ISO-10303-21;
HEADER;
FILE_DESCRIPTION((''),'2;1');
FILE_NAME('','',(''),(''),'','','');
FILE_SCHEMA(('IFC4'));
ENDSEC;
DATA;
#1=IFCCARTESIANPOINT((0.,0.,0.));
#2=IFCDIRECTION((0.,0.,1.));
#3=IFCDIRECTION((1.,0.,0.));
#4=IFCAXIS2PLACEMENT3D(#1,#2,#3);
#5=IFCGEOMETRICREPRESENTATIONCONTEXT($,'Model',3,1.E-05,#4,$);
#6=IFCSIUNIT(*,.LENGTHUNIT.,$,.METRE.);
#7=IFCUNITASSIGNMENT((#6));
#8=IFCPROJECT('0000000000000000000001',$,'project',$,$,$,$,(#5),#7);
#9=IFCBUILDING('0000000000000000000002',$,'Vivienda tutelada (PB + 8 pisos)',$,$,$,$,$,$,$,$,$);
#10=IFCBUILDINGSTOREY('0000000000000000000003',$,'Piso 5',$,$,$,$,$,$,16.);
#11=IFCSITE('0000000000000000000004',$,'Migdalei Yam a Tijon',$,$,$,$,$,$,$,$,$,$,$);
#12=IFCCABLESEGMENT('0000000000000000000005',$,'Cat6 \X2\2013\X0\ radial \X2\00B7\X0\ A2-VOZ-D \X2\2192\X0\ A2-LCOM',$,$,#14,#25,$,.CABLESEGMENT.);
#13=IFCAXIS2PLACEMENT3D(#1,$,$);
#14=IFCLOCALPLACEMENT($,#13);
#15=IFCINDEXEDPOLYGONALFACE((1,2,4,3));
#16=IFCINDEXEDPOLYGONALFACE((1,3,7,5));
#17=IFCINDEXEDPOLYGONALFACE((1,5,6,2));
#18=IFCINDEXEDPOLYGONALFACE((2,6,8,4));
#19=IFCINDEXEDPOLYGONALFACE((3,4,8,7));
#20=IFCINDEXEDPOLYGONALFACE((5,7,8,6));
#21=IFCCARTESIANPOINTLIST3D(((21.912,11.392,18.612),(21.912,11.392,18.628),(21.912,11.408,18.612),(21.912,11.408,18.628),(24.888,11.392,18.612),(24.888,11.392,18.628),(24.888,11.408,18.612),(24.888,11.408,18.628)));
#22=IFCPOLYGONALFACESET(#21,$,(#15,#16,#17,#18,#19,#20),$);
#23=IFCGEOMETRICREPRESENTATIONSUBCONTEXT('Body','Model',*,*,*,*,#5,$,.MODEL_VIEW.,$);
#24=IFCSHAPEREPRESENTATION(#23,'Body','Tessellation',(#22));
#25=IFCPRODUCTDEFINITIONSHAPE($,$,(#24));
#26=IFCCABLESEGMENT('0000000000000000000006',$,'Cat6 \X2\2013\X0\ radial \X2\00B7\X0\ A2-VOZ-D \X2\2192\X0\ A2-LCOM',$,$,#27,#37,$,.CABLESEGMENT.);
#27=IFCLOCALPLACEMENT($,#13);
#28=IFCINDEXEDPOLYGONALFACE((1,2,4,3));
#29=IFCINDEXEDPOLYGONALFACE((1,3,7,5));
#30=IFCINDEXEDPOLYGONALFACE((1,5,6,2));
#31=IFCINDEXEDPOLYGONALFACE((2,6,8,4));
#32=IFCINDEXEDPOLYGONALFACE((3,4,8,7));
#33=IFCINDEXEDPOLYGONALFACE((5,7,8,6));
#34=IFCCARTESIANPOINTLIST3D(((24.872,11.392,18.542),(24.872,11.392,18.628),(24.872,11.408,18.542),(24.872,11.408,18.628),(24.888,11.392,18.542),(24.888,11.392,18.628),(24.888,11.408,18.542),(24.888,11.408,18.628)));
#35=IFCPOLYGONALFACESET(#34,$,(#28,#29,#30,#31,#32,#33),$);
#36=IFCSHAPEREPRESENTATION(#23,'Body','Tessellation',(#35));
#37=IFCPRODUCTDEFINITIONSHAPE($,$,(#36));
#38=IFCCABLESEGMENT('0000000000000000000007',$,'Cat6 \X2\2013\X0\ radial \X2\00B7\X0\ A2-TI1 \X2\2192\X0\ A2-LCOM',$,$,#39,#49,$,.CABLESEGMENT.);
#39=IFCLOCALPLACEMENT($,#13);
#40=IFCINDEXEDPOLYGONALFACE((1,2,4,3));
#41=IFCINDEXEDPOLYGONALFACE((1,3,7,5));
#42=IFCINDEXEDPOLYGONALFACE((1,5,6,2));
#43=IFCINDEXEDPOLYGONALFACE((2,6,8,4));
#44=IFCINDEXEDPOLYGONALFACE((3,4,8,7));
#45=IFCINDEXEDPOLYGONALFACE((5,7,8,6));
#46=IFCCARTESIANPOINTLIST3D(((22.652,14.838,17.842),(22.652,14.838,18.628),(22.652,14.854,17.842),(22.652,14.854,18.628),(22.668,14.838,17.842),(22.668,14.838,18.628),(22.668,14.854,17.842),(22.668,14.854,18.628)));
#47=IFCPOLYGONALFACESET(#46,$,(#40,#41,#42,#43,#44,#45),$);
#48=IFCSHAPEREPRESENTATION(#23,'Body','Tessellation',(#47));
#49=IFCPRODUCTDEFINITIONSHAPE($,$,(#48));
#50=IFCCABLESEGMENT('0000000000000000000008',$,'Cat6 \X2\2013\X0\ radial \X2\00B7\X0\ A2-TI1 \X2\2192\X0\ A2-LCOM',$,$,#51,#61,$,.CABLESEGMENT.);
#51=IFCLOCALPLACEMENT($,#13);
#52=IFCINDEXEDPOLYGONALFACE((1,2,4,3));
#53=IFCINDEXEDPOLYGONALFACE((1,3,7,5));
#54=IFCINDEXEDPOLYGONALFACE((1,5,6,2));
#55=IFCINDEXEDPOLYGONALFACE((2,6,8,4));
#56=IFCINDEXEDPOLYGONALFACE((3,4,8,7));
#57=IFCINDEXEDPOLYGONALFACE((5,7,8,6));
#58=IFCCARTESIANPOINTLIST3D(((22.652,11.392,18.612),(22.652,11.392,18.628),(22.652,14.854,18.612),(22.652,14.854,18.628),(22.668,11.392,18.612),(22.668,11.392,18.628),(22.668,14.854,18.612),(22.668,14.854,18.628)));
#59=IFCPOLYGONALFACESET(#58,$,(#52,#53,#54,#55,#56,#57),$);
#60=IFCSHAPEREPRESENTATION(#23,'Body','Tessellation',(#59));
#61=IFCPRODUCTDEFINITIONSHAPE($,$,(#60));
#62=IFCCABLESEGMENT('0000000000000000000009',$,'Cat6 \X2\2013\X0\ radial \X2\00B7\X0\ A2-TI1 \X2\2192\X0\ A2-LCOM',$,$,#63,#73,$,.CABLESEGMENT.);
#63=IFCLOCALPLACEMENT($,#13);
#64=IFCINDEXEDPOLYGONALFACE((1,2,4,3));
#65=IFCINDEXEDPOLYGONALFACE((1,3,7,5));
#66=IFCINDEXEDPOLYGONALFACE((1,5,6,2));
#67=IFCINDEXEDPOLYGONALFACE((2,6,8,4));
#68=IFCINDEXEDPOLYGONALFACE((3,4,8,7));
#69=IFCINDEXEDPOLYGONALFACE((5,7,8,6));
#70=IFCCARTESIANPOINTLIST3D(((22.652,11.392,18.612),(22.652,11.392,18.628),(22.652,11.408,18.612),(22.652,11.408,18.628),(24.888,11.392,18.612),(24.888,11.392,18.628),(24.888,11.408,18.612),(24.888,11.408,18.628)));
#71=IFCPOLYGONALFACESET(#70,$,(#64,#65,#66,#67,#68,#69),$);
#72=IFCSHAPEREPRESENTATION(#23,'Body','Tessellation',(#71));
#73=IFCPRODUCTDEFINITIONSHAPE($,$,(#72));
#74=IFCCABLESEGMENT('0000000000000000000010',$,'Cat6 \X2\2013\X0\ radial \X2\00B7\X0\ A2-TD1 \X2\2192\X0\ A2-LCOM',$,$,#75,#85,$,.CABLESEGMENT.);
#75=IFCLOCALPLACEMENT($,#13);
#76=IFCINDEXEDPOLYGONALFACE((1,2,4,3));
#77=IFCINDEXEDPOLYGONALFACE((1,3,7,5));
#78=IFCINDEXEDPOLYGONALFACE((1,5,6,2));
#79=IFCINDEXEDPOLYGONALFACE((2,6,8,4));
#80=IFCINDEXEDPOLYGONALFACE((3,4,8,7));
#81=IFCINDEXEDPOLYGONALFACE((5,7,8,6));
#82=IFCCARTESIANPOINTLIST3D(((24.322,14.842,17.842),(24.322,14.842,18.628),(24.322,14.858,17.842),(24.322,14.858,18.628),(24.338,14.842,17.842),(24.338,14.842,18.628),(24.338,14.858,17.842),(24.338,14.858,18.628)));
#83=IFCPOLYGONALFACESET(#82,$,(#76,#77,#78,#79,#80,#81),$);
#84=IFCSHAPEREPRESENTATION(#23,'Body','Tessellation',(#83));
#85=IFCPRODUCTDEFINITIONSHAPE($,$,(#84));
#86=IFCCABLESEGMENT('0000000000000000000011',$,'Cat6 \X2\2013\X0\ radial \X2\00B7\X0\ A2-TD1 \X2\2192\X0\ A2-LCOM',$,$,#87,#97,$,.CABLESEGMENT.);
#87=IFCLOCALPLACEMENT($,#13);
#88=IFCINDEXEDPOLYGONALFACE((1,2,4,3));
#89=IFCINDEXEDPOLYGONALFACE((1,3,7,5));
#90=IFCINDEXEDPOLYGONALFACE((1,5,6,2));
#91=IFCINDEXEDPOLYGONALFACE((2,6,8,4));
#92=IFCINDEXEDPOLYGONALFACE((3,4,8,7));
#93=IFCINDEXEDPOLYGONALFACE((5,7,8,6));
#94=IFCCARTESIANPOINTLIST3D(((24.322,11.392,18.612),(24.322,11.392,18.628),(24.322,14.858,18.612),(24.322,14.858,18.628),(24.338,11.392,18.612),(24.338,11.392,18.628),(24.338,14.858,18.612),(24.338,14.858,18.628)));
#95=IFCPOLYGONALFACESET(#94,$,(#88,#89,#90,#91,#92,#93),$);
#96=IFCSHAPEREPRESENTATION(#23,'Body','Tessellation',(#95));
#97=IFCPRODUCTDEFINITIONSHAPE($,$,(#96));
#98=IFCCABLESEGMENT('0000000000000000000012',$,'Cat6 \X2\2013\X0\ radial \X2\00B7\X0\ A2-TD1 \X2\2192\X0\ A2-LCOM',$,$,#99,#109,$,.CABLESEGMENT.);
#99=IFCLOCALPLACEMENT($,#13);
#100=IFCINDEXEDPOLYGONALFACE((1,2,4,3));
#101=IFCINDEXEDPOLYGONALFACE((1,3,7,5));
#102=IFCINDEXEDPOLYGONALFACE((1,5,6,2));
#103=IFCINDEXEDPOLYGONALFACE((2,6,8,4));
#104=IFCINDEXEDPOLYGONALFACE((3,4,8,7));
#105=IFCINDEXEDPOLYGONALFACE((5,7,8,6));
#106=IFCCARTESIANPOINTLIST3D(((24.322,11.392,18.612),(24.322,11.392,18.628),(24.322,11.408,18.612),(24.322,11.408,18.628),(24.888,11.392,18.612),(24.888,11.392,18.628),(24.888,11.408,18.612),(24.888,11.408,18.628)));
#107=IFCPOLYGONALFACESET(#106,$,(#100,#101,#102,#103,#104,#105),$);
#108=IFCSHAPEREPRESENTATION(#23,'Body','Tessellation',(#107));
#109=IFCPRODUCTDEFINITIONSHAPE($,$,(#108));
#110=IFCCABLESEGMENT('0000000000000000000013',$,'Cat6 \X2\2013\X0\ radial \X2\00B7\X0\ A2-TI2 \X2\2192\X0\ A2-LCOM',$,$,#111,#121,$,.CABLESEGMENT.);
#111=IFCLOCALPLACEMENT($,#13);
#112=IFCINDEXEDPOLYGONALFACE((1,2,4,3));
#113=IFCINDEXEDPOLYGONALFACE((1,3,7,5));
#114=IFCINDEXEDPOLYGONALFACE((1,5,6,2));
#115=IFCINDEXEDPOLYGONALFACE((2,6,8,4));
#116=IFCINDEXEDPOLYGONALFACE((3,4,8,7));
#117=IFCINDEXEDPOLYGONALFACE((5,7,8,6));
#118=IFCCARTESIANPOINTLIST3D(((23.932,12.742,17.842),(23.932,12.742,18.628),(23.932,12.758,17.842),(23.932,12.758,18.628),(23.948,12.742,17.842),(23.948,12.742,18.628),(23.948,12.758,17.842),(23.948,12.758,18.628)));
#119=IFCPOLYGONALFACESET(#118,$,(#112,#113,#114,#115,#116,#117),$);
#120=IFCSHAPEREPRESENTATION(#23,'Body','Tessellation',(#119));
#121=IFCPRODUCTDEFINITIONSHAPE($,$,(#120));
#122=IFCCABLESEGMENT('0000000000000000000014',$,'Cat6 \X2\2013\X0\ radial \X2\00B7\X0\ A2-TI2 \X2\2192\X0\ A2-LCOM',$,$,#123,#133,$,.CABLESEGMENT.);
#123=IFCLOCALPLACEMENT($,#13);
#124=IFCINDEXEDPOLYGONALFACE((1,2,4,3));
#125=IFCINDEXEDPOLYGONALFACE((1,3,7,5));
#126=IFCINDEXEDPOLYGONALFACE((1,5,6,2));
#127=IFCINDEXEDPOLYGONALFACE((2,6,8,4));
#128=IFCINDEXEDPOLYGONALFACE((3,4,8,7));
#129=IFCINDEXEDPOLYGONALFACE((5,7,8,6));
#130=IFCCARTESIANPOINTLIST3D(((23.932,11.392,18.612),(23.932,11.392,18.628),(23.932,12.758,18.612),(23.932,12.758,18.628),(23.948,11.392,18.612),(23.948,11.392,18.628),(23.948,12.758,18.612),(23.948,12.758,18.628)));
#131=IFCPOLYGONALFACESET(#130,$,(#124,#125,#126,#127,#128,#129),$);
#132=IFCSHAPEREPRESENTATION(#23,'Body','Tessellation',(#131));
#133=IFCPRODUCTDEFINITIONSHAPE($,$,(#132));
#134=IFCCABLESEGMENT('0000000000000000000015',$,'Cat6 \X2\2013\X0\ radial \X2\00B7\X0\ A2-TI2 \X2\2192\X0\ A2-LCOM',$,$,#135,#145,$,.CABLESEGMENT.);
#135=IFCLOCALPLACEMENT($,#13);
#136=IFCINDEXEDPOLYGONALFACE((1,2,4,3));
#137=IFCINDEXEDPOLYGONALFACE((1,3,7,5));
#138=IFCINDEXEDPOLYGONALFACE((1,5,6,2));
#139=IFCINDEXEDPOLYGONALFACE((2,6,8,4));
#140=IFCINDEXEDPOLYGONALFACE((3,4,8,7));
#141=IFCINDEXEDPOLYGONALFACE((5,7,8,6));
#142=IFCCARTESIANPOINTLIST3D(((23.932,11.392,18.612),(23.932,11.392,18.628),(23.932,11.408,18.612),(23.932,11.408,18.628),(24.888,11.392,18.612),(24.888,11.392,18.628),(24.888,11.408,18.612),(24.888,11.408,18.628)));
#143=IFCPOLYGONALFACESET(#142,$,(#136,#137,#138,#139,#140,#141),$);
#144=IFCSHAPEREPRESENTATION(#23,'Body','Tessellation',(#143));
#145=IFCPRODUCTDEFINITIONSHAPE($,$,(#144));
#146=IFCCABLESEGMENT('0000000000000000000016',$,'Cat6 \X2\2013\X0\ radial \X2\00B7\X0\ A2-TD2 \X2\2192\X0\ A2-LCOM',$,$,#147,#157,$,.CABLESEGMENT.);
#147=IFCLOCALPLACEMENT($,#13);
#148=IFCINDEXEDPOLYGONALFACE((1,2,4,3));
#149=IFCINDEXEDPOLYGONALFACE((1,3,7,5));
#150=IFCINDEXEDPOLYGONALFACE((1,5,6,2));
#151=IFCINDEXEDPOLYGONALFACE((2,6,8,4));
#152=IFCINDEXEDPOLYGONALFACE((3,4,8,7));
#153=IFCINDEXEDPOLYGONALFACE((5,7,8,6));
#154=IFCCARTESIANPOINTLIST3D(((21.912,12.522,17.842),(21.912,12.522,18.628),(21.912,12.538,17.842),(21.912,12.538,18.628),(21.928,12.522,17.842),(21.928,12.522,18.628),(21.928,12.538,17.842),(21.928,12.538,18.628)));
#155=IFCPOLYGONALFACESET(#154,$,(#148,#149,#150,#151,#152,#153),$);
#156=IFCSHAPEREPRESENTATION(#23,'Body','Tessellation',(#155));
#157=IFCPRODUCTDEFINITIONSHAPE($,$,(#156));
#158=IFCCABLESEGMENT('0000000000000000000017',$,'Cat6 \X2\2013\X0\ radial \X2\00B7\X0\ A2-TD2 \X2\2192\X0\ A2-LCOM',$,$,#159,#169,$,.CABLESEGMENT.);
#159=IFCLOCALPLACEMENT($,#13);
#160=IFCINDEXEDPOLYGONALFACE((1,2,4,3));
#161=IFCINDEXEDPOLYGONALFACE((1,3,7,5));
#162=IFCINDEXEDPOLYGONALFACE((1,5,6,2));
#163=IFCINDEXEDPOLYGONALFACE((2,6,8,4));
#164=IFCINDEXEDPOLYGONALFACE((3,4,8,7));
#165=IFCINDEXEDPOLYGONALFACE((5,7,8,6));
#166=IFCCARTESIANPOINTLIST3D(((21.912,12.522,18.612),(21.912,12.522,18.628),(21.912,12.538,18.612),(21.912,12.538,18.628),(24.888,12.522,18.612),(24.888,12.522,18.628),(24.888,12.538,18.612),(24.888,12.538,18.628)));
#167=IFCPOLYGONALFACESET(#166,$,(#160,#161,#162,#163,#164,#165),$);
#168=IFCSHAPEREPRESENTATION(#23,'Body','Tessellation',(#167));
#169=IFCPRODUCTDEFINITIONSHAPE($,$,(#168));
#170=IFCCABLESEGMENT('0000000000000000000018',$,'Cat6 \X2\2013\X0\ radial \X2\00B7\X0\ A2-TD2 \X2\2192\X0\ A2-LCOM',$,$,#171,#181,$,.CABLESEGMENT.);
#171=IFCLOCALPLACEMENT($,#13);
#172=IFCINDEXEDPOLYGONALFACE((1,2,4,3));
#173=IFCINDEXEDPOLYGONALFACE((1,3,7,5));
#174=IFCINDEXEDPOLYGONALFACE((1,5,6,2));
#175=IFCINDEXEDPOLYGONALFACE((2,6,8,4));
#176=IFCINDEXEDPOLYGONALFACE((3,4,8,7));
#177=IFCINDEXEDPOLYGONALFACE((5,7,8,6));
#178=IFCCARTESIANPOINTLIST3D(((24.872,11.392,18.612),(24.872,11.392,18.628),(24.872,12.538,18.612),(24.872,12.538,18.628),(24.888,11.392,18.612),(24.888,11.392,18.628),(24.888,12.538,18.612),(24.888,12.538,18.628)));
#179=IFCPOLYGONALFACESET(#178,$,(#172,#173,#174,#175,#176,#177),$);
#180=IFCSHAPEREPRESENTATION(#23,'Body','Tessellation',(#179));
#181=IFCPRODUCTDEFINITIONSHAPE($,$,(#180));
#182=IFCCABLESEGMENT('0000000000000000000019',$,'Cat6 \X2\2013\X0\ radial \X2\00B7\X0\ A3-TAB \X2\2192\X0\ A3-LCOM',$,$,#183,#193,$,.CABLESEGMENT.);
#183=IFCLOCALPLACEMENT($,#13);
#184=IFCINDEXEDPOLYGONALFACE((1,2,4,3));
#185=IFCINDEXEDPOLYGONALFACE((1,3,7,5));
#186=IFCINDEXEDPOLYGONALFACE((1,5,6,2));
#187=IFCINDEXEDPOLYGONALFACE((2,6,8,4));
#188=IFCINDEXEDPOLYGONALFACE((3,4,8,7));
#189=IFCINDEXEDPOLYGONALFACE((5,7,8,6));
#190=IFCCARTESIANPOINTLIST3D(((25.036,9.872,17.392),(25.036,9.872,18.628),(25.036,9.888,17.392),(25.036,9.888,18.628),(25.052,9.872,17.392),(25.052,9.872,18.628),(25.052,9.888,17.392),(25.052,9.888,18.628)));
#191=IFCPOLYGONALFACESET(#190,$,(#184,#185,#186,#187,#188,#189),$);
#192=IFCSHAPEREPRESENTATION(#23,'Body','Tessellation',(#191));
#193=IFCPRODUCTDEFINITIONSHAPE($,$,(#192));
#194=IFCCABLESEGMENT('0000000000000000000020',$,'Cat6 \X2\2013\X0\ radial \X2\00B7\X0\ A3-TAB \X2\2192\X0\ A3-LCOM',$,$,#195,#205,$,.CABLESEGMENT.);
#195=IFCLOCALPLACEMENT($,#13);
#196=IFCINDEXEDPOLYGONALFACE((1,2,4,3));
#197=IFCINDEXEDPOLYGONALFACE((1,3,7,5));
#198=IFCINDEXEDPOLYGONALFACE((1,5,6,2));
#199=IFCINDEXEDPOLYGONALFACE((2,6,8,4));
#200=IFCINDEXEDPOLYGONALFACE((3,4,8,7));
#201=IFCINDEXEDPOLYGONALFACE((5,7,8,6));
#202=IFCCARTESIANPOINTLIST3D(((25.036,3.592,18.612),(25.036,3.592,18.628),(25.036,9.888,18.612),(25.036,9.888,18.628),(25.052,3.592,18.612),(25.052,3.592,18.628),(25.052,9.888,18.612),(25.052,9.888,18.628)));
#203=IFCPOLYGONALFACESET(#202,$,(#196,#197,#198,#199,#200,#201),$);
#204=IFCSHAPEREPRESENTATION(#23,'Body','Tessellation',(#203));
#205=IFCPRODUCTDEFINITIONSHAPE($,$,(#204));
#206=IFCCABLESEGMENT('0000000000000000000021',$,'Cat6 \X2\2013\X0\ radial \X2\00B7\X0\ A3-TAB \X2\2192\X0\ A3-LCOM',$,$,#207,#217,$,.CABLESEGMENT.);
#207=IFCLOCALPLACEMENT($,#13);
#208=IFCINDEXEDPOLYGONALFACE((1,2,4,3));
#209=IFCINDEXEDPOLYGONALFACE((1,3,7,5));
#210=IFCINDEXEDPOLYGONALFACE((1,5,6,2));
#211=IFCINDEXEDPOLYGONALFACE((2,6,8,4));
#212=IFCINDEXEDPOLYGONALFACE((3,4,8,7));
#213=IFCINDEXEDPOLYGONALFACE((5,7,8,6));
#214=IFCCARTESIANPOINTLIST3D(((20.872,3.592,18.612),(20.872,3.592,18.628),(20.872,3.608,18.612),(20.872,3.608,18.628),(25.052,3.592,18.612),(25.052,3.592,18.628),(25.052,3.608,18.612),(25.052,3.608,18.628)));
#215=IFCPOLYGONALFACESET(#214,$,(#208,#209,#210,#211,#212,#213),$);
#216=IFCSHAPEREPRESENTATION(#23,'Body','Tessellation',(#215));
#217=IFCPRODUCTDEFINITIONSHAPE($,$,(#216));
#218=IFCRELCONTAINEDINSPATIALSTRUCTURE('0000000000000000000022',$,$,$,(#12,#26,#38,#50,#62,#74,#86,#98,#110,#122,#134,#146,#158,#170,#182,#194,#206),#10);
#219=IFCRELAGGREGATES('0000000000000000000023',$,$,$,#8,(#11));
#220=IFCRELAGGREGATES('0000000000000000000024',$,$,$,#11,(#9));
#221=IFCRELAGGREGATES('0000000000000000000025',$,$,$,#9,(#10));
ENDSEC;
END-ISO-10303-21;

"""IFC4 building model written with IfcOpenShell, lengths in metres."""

from ifc_helpers import new_model, si_unit, frame, origin_with_axes, context, subcontext, project, spatial, line, indexed_curve, outline, extrude, element, save


model = new_model("IFC4")

# Units and contexts
model_context = context("Model", 3, precision=1e-05, world=origin_with_axes())
body_context = subcontext(model_context, "Body", "Model", "MODEL_VIEW")
ifc_project = project(units=[si_unit("LENGTHUNIT", "METRE")], contexts=[model_context])

# Site, building, storey
site = spatial("IfcSite", under=ifc_project, Name="Migdalei Yam a Tijon")
building = spatial("IfcBuilding", under=site, Name="Vivienda tutelada (PB + 8 pisos)")
storey = spatial("IfcBuildingStorey", under=building, Name="Piso 5", Elevation=16.0)

# Cable segments
element("IfcCableSegment", 1, inside=storey, Name="Cat6 – radial · A2-VOZ-D → A2-LCOM", PredefinedType="CABLESEGMENT", context=body_context, shape_type="SweptSolid", body=[
    extrude(outline(indexed_curve([(0.0, 0.0), (2.976, 0.0), (2.976, 0.016), (0.0, 0.016)], segments=[line(1, 2, 3, 4, 1)])), frame((21.912, 11.392, 18.612), z_axis=(0.0, 0.0, 1.0), x_axis=(1.0, 0.0, 0.0)), (0.0, 0.0, 1.0), 0.016),
])
element("IfcCableSegment", 2, inside=storey, Name="Cat6 – radial · A2-VOZ-D → A2-LCOM", PredefinedType="CABLESEGMENT", context=body_context, shape_type="SweptSolid", body=[
    extrude(outline(indexed_curve([(0.0, 0.0), (0.016, 0.0), (0.016, 0.016), (0.0, 0.016)], segments=[line(1, 2, 3, 4, 1)])), frame((24.872, 11.392, 18.542), z_axis=(0.0, 0.0, 1.0), x_axis=(1.0, 0.0, 0.0)), (0.0, 0.0, 1.0), 0.086),
])
element("IfcCableSegment", 3, inside=storey, Name="Cat6 – radial · A2-TI1 → A2-LCOM", PredefinedType="CABLESEGMENT", context=body_context, shape_type="SweptSolid", body=[
    extrude(outline(indexed_curve([(0.0, 0.0), (0.016, 0.0), (0.016, 0.016), (0.0, 0.016)], segments=[line(1, 2, 3, 4, 1)])), frame((22.652, 14.838, 17.842), z_axis=(0.0, 0.0, 1.0), x_axis=(1.0, 0.0, 0.0)), (0.0, 0.0, 1.0), 0.786),
])
element("IfcCableSegment", 4, inside=storey, Name="Cat6 – radial · A2-TI1 → A2-LCOM", PredefinedType="CABLESEGMENT", context=body_context, shape_type="SweptSolid", body=[
    extrude(outline(indexed_curve([(0.0, 0.0), (0.016, 0.0), (0.016, 3.462), (0.0, 3.462)], segments=[line(1, 2, 3, 4, 1)])), frame((22.652, 11.392, 18.612), z_axis=(0.0, 0.0, 1.0), x_axis=(1.0, 0.0, 0.0)), (0.0, 0.0, 1.0), 0.016),
])
element("IfcCableSegment", 5, inside=storey, Name="Cat6 – radial · A2-TI1 → A2-LCOM", PredefinedType="CABLESEGMENT", context=body_context, shape_type="SweptSolid", body=[
    extrude(outline(indexed_curve([(0.0, 0.0), (2.236, 0.0), (2.236, 0.016), (0.0, 0.016)], segments=[line(1, 2, 3, 4, 1)])), frame((22.652, 11.392, 18.612), z_axis=(0.0, 0.0, 1.0), x_axis=(1.0, 0.0, 0.0)), (0.0, 0.0, 1.0), 0.016),
])
element("IfcCableSegment", 6, inside=storey, Name="Cat6 – radial · A2-TD1 → A2-LCOM", PredefinedType="CABLESEGMENT", context=body_context, shape_type="SweptSolid", body=[
    extrude(outline(indexed_curve([(0.0, 0.0), (0.016, 0.0), (0.016, 0.016), (0.0, 0.016)], segments=[line(1, 2, 3, 4, 1)])), frame((24.322, 14.842, 17.842), z_axis=(0.0, 0.0, 1.0), x_axis=(1.0, 0.0, 0.0)), (0.0, 0.0, 1.0), 0.786),
])
element("IfcCableSegment", 7, inside=storey, Name="Cat6 – radial · A2-TD1 → A2-LCOM", PredefinedType="CABLESEGMENT", context=body_context, shape_type="SweptSolid", body=[
    extrude(outline(indexed_curve([(0.0, 0.0), (0.016, 0.0), (0.016, 3.466), (0.0, 3.466)], segments=[line(1, 2, 3, 4, 1)])), frame((24.322, 11.392, 18.612), z_axis=(0.0, 0.0, 1.0), x_axis=(1.0, 0.0, 0.0)), (0.0, 0.0, 1.0), 0.016),
])
element("IfcCableSegment", 8, inside=storey, Name="Cat6 – radial · A2-TD1 → A2-LCOM", PredefinedType="CABLESEGMENT", context=body_context, shape_type="SweptSolid", body=[
    extrude(outline(indexed_curve([(0.0, 0.0), (0.566, 0.0), (0.566, 0.016), (0.0, 0.016)], segments=[line(1, 2, 3, 4, 1)])), frame((24.322, 11.392, 18.612), z_axis=(0.0, 0.0, 1.0), x_axis=(1.0, 0.0, 0.0)), (0.0, 0.0, 1.0), 0.016),
])
element("IfcCableSegment", 9, inside=storey, Name="Cat6 – radial · A2-TI2 → A2-LCOM", PredefinedType="CABLESEGMENT", context=body_context, shape_type="SweptSolid", body=[
    extrude(outline(indexed_curve([(0.0, 0.0), (0.016, 0.0), (0.016, 0.016), (0.0, 0.016)], segments=[line(1, 2, 3, 4, 1)])), frame((23.932, 12.742, 17.842), z_axis=(0.0, 0.0, 1.0), x_axis=(1.0, 0.0, 0.0)), (0.0, 0.0, 1.0), 0.786),
])
element("IfcCableSegment", 10, inside=storey, Name="Cat6 – radial · A2-TI2 → A2-LCOM", PredefinedType="CABLESEGMENT", context=body_context, shape_type="SweptSolid", body=[
    extrude(outline(indexed_curve([(0.0, 0.0), (0.016, 0.0), (0.016, 1.366), (0.0, 1.366)], segments=[line(1, 2, 3, 4, 1)])), frame((23.932, 11.392, 18.612), z_axis=(0.0, 0.0, 1.0), x_axis=(1.0, 0.0, 0.0)), (0.0, 0.0, 1.0), 0.016),
])
element("IfcCableSegment", 11, inside=storey, Name="Cat6 – radial · A2-TI2 → A2-LCOM", PredefinedType="CABLESEGMENT", context=body_context, shape_type="SweptSolid", body=[
    extrude(outline(indexed_curve([(0.0, 0.0), (0.956, 0.0), (0.956, 0.016), (0.0, 0.016)], segments=[line(1, 2, 3, 4, 1)])), frame((23.932, 11.392, 18.612), z_axis=(0.0, 0.0, 1.0), x_axis=(1.0, 0.0, 0.0)), (0.0, 0.0, 1.0), 0.016),
])
element("IfcCableSegment", 12, inside=storey, Name="Cat6 – radial · A2-TD2 → A2-LCOM", PredefinedType="CABLESEGMENT", context=body_context, shape_type="SweptSolid", body=[
    extrude(outline(indexed_curve([(0.0, 0.0), (0.016, 0.0), (0.016, 0.016), (0.0, 0.016)], segments=[line(1, 2, 3, 4, 1)])), frame((21.912, 12.522, 17.842), z_axis=(0.0, 0.0, 1.0), x_axis=(1.0, 0.0, 0.0)), (0.0, 0.0, 1.0), 0.786),
])
element("IfcCableSegment", 13, inside=storey, Name="Cat6 – radial · A2-TD2 → A2-LCOM", PredefinedType="CABLESEGMENT", context=body_context, shape_type="SweptSolid", body=[
    extrude(outline(indexed_curve([(0.0, 0.0), (2.976, 0.0), (2.976, 0.016), (0.0, 0.016)], segments=[line(1, 2, 3, 4, 1)])), frame((21.912, 12.522, 18.612), z_axis=(0.0, 0.0, 1.0), x_axis=(1.0, 0.0, 0.0)), (0.0, 0.0, 1.0), 0.016),
])
element("IfcCableSegment", 14, inside=storey, Name="Cat6 – radial · A2-TD2 → A2-LCOM", PredefinedType="CABLESEGMENT", context=body_context, shape_type="SweptSolid", body=[
    extrude(outline(indexed_curve([(0.0, 0.0), (0.016, 0.0), (0.016, 1.146), (0.0, 1.146)], segments=[line(1, 2, 3, 4, 1)])), frame((24.872, 11.392, 18.612), z_axis=(0.0, 0.0, 1.0), x_axis=(1.0, 0.0, 0.0)), (0.0, 0.0, 1.0), 0.016),
])
element("IfcCableSegment", 15, inside=storey, Name="Cat6 – radial · A3-TAB → A3-LCOM", PredefinedType="CABLESEGMENT", context=body_context, shape_type="SweptSolid", body=[
    extrude(outline(indexed_curve([(0.0, 0.0), (0.016, 0.0), (0.016, 0.016), (0.0, 0.016)], segments=[line(1, 2, 3, 4, 1)])), frame((25.036, 9.872, 17.392), z_axis=(0.0, 0.0, 1.0), x_axis=(1.0, 0.0, 0.0)), (0.0, 0.0, 1.0), 1.236),
])
element("IfcCableSegment", 16, inside=storey, Name="Cat6 – radial · A3-TAB → A3-LCOM", PredefinedType="CABLESEGMENT", context=body_context, shape_type="SweptSolid", body=[
    extrude(outline(indexed_curve([(0.0, 0.0), (0.016, 0.0), (0.016, 6.296), (0.0, 6.296)], segments=[line(1, 2, 3, 4, 1)])), frame((25.036, 3.592, 18.612), z_axis=(0.0, 0.0, 1.0), x_axis=(1.0, 0.0, 0.0)), (0.0, 0.0, 1.0), 0.016),
])
element("IfcCableSegment", 17, inside=storey, Name="Cat6 – radial · A3-TAB → A3-LCOM", PredefinedType="CABLESEGMENT", context=body_context, shape_type="SweptSolid", body=[
    extrude(outline(indexed_curve([(0.0, 0.0), (4.18, 0.0), (4.18, 0.016), (0.0, 0.016)], segments=[line(1, 2, 3, 4, 1)])), frame((20.872, 3.592, 18.612), z_axis=(0.0, 0.0, 1.0), x_axis=(1.0, 0.0, 0.0)), (0.0, 0.0, 1.0), 0.016),
])

save(model, "model.ifc")
